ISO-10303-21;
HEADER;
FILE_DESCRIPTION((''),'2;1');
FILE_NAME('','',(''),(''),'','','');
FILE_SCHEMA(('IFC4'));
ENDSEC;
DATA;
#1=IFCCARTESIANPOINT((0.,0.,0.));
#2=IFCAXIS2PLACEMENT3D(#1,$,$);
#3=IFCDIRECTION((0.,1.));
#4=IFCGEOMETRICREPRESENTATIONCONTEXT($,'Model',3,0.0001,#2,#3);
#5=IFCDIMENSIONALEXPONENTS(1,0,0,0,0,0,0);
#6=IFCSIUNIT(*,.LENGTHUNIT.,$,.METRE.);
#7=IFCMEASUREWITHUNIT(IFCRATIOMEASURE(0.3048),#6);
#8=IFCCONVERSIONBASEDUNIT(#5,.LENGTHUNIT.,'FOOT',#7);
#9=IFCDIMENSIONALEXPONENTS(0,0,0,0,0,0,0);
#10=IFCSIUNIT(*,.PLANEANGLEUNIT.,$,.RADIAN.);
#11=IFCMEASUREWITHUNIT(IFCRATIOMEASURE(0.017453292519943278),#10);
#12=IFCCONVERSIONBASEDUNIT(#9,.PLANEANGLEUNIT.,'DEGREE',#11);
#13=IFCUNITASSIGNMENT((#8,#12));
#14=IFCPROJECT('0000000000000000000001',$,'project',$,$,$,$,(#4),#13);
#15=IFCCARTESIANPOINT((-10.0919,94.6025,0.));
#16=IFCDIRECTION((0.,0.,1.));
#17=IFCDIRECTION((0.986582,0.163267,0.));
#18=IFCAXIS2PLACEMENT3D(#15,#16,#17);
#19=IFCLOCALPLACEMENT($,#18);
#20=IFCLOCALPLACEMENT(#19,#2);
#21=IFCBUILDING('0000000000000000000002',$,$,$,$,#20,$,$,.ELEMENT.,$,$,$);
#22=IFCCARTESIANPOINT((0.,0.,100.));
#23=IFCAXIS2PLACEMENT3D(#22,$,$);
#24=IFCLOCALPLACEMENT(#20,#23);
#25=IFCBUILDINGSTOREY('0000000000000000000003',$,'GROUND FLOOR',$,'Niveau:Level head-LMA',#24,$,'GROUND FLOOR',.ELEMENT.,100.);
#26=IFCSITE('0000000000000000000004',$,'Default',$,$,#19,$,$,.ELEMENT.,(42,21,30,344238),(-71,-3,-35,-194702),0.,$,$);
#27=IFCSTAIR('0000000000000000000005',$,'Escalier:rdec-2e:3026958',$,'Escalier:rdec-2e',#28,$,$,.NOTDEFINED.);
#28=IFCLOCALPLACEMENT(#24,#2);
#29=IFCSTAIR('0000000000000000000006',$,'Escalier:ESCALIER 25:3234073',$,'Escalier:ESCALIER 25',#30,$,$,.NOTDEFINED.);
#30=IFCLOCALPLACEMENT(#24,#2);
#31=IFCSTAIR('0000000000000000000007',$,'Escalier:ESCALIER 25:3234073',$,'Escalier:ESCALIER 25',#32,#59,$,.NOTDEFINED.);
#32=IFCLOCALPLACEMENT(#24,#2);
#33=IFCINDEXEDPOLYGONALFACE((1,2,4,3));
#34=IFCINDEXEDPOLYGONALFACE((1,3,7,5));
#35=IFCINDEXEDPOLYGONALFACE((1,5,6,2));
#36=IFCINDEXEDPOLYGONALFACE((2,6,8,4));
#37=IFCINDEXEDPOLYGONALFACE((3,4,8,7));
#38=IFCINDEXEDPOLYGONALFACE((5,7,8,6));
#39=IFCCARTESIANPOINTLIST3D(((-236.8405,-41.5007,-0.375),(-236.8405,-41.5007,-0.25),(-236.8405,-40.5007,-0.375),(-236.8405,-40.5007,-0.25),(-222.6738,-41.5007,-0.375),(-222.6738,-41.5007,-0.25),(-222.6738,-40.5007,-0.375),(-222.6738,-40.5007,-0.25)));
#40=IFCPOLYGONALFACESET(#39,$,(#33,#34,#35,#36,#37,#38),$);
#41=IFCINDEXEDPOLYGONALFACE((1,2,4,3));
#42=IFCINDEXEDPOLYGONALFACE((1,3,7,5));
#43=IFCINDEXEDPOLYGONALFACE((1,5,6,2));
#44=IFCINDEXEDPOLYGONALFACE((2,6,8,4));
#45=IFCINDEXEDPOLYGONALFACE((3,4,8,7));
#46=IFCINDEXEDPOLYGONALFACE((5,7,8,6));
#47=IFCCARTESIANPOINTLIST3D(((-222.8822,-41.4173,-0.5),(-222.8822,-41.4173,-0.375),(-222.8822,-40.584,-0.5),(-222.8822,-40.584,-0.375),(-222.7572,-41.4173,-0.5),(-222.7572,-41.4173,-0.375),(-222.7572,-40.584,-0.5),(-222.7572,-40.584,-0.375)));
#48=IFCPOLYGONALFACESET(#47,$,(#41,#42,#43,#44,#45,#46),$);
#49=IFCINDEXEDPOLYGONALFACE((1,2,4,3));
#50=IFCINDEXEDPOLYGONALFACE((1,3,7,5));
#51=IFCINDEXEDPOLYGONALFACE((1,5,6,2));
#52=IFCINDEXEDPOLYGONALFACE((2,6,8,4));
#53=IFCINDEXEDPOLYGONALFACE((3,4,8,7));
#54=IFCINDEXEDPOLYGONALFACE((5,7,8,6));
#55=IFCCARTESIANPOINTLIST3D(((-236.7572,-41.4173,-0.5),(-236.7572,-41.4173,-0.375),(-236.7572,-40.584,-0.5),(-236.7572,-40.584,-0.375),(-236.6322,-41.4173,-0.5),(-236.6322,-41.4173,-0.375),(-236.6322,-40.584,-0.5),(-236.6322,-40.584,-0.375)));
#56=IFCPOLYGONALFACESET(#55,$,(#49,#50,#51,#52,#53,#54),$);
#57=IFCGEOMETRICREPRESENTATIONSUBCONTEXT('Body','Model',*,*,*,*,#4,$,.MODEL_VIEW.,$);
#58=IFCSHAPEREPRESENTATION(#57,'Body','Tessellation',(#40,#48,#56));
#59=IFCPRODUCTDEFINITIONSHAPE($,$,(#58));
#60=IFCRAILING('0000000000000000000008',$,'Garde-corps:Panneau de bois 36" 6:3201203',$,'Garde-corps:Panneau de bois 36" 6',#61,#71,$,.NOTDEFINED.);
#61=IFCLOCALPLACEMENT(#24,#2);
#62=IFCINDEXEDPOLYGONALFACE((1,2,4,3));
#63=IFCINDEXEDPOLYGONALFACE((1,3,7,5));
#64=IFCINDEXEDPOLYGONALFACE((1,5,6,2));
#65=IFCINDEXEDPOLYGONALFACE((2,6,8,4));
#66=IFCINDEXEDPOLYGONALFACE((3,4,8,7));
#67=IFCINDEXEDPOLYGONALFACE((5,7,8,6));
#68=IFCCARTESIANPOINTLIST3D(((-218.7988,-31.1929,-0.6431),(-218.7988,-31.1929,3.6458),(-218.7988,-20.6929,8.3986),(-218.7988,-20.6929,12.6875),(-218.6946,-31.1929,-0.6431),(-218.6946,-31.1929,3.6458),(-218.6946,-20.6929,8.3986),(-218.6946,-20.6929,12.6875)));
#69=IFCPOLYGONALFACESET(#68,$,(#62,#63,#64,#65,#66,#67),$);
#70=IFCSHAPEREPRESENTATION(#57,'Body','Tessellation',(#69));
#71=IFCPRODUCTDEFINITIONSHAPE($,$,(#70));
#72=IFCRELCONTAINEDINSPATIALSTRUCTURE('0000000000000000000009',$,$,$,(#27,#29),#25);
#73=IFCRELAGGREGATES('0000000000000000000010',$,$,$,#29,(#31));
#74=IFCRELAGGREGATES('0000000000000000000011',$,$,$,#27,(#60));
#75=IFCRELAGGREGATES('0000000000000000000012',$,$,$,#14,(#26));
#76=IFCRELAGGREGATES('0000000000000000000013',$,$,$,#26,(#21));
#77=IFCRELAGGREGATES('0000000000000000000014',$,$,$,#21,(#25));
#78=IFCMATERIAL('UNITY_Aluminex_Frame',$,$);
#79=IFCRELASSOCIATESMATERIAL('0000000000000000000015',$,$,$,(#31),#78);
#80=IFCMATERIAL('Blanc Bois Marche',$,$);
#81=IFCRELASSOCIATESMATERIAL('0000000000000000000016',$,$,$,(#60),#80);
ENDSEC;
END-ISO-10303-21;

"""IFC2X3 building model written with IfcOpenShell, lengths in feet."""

from ifc_helpers import new_model, entity, si_unit, converted_unit, direction, frame, frame_2d, origin, place, context, subcontext, project, spatial, polyline, rectangle, outline, extrude, material, element, aggregate, save


model = new_model("IFC2X3")

# Units and contexts
model_context = context("Model", 3, precision=0.0001, world=origin(), true_north=direction((0.0, 1.0)))
body_context = subcontext(model_context, "Body", "Model", "MODEL_VIEW")
ifc_project = project(units=[converted_unit("LENGTHUNIT", "FOOT", entity("IfcRatioMeasure", 0.3048), si_unit("LENGTHUNIT", "METRE"), dimensions=[1, 0, 0, 0, 0, 0, 0]), converted_unit("PLANEANGLEUNIT", "DEGREE", entity("IfcRatioMeasure", 0.017453292519943278), si_unit("PLANEANGLEUNIT", "RADIAN"), dimensions=[0, 0, 0, 0, 0, 0, 0])], contexts=[model_context])

# Site, building, storey
site_placement = place(None, frame((-10.0919, 94.6025, 0.0), z_axis=(0.0, 0.0, 1.0), x_axis=(0.986582, 0.163267, 0.0)))
site = spatial("IfcSite", under=ifc_project, at=site_placement, Name="Default", CompositionType="ELEMENT", RefLatitude=(42, 21, 30, 344238), RefLongitude=(-71, -3, -35, -194702), RefElevation=0.0)
building_placement = place(site_placement, origin())
building = spatial("IfcBuilding", under=site, at=building_placement, CompositionType="ELEMENT")
storey_placement = place(building_placement, frame((0.0, 0.0, 100.0)))
storey = spatial("IfcBuildingStorey", under=building, at=storey_placement, Name="GROUND FLOOR", ObjectType="Niveau:Level head-LMA", LongName="GROUND FLOOR", CompositionType="ELEMENT", Elevation=100.0)

# Stairs
stair_1_placement = place(storey_placement, origin())
stair_1 = element("IfcStair", 1, at=stair_1_placement, inside=storey, Name="Escalier:rdec-2e:3026958", ObjectType="Escalier:rdec-2e", ShapeType="NOTDEFINED")
stair_2_placement = place(storey_placement, origin())
stair_2 = element("IfcStair", 2, at=stair_2_placement, inside=storey, Name="Escalier:ESCALIER 25:3234073", ObjectType="Escalier:ESCALIER 25", ShapeType="NOTDEFINED")
ifc_material_1 = material(Name="UNITY_Aluminex_Frame")
stair_3_placement = place(stair_2_placement, origin())
stair_3 = element("IfcStair", 3, at=stair_3_placement, material=ifc_material_1, Name="Escalier:ESCALIER 25:3234073", ObjectType="Escalier:ESCALIER 25", ShapeType="NOTDEFINED", context=body_context, shape_type="SweptSolid", body=[
    extrude(rectangle(XDim=1.0, YDim=14.1667, at=frame_2d((0.0, 0.0), x_axis=(1.0, 0.0))), frame((-229.7572, -41.0007, -0.375), z_axis=(0.0, 0.0, 1.0), x_axis=(0.0, -1.0, 0.0)), (0.0, 0.0, 1.0), 0.125),
    extrude(rectangle(XDim=0.8333, YDim=0.125, at=frame_2d((0.0, 0.0), x_axis=(1.0, 0.0))), frame((-222.8197, -41.0007, -0.5), z_axis=(0.0, 0.0, 1.0), x_axis=(0.0, -1.0, 0.0)), (0.0, 0.0, 1.0), 0.125),
    extrude(rectangle(XDim=0.8333, YDim=0.125, at=frame_2d((0.0, 0.0), x_axis=(1.0, 0.0))), frame((-236.6947, -41.0007, -0.5), z_axis=(0.0, 0.0, 1.0), x_axis=(0.0, -1.0, 0.0)), (0.0, 0.0, 1.0), 0.125),
])
aggregate(stair_2, [stair_3])

# Railing
ifc_material_2 = material(Name="Blanc Bois Marche")
railing_placement = place(stair_1_placement, frame((0.0, 0.0, 9.3333)))
railing = element("IfcRailing", 4, at=railing_placement, material=ifc_material_2, Name="Garde-corps:Panneau de bois 36\" 6:3201203", ObjectType="Garde-corps:Panneau de bois 36\" 6", PredefinedType="NOTDEFINED", context=body_context, shape_type="SweptSolid", body=[
    extrude(outline(polyline([(-8.3275, -1.625), (5.5289, -1.625), (8.3275, 1.625), (-5.5289, 1.625), (-8.3275, -1.625)])), frame((-218.7988, -25.9429, -3.3111), z_axis=(1.0, 0.0, 0.0), x_axis=(0.0, -0.757769, -0.652523)), (0.0, 0.0, 1.0), 0.1042),
])
aggregate(stair_1, [railing])

save(model, "model.ifc")
